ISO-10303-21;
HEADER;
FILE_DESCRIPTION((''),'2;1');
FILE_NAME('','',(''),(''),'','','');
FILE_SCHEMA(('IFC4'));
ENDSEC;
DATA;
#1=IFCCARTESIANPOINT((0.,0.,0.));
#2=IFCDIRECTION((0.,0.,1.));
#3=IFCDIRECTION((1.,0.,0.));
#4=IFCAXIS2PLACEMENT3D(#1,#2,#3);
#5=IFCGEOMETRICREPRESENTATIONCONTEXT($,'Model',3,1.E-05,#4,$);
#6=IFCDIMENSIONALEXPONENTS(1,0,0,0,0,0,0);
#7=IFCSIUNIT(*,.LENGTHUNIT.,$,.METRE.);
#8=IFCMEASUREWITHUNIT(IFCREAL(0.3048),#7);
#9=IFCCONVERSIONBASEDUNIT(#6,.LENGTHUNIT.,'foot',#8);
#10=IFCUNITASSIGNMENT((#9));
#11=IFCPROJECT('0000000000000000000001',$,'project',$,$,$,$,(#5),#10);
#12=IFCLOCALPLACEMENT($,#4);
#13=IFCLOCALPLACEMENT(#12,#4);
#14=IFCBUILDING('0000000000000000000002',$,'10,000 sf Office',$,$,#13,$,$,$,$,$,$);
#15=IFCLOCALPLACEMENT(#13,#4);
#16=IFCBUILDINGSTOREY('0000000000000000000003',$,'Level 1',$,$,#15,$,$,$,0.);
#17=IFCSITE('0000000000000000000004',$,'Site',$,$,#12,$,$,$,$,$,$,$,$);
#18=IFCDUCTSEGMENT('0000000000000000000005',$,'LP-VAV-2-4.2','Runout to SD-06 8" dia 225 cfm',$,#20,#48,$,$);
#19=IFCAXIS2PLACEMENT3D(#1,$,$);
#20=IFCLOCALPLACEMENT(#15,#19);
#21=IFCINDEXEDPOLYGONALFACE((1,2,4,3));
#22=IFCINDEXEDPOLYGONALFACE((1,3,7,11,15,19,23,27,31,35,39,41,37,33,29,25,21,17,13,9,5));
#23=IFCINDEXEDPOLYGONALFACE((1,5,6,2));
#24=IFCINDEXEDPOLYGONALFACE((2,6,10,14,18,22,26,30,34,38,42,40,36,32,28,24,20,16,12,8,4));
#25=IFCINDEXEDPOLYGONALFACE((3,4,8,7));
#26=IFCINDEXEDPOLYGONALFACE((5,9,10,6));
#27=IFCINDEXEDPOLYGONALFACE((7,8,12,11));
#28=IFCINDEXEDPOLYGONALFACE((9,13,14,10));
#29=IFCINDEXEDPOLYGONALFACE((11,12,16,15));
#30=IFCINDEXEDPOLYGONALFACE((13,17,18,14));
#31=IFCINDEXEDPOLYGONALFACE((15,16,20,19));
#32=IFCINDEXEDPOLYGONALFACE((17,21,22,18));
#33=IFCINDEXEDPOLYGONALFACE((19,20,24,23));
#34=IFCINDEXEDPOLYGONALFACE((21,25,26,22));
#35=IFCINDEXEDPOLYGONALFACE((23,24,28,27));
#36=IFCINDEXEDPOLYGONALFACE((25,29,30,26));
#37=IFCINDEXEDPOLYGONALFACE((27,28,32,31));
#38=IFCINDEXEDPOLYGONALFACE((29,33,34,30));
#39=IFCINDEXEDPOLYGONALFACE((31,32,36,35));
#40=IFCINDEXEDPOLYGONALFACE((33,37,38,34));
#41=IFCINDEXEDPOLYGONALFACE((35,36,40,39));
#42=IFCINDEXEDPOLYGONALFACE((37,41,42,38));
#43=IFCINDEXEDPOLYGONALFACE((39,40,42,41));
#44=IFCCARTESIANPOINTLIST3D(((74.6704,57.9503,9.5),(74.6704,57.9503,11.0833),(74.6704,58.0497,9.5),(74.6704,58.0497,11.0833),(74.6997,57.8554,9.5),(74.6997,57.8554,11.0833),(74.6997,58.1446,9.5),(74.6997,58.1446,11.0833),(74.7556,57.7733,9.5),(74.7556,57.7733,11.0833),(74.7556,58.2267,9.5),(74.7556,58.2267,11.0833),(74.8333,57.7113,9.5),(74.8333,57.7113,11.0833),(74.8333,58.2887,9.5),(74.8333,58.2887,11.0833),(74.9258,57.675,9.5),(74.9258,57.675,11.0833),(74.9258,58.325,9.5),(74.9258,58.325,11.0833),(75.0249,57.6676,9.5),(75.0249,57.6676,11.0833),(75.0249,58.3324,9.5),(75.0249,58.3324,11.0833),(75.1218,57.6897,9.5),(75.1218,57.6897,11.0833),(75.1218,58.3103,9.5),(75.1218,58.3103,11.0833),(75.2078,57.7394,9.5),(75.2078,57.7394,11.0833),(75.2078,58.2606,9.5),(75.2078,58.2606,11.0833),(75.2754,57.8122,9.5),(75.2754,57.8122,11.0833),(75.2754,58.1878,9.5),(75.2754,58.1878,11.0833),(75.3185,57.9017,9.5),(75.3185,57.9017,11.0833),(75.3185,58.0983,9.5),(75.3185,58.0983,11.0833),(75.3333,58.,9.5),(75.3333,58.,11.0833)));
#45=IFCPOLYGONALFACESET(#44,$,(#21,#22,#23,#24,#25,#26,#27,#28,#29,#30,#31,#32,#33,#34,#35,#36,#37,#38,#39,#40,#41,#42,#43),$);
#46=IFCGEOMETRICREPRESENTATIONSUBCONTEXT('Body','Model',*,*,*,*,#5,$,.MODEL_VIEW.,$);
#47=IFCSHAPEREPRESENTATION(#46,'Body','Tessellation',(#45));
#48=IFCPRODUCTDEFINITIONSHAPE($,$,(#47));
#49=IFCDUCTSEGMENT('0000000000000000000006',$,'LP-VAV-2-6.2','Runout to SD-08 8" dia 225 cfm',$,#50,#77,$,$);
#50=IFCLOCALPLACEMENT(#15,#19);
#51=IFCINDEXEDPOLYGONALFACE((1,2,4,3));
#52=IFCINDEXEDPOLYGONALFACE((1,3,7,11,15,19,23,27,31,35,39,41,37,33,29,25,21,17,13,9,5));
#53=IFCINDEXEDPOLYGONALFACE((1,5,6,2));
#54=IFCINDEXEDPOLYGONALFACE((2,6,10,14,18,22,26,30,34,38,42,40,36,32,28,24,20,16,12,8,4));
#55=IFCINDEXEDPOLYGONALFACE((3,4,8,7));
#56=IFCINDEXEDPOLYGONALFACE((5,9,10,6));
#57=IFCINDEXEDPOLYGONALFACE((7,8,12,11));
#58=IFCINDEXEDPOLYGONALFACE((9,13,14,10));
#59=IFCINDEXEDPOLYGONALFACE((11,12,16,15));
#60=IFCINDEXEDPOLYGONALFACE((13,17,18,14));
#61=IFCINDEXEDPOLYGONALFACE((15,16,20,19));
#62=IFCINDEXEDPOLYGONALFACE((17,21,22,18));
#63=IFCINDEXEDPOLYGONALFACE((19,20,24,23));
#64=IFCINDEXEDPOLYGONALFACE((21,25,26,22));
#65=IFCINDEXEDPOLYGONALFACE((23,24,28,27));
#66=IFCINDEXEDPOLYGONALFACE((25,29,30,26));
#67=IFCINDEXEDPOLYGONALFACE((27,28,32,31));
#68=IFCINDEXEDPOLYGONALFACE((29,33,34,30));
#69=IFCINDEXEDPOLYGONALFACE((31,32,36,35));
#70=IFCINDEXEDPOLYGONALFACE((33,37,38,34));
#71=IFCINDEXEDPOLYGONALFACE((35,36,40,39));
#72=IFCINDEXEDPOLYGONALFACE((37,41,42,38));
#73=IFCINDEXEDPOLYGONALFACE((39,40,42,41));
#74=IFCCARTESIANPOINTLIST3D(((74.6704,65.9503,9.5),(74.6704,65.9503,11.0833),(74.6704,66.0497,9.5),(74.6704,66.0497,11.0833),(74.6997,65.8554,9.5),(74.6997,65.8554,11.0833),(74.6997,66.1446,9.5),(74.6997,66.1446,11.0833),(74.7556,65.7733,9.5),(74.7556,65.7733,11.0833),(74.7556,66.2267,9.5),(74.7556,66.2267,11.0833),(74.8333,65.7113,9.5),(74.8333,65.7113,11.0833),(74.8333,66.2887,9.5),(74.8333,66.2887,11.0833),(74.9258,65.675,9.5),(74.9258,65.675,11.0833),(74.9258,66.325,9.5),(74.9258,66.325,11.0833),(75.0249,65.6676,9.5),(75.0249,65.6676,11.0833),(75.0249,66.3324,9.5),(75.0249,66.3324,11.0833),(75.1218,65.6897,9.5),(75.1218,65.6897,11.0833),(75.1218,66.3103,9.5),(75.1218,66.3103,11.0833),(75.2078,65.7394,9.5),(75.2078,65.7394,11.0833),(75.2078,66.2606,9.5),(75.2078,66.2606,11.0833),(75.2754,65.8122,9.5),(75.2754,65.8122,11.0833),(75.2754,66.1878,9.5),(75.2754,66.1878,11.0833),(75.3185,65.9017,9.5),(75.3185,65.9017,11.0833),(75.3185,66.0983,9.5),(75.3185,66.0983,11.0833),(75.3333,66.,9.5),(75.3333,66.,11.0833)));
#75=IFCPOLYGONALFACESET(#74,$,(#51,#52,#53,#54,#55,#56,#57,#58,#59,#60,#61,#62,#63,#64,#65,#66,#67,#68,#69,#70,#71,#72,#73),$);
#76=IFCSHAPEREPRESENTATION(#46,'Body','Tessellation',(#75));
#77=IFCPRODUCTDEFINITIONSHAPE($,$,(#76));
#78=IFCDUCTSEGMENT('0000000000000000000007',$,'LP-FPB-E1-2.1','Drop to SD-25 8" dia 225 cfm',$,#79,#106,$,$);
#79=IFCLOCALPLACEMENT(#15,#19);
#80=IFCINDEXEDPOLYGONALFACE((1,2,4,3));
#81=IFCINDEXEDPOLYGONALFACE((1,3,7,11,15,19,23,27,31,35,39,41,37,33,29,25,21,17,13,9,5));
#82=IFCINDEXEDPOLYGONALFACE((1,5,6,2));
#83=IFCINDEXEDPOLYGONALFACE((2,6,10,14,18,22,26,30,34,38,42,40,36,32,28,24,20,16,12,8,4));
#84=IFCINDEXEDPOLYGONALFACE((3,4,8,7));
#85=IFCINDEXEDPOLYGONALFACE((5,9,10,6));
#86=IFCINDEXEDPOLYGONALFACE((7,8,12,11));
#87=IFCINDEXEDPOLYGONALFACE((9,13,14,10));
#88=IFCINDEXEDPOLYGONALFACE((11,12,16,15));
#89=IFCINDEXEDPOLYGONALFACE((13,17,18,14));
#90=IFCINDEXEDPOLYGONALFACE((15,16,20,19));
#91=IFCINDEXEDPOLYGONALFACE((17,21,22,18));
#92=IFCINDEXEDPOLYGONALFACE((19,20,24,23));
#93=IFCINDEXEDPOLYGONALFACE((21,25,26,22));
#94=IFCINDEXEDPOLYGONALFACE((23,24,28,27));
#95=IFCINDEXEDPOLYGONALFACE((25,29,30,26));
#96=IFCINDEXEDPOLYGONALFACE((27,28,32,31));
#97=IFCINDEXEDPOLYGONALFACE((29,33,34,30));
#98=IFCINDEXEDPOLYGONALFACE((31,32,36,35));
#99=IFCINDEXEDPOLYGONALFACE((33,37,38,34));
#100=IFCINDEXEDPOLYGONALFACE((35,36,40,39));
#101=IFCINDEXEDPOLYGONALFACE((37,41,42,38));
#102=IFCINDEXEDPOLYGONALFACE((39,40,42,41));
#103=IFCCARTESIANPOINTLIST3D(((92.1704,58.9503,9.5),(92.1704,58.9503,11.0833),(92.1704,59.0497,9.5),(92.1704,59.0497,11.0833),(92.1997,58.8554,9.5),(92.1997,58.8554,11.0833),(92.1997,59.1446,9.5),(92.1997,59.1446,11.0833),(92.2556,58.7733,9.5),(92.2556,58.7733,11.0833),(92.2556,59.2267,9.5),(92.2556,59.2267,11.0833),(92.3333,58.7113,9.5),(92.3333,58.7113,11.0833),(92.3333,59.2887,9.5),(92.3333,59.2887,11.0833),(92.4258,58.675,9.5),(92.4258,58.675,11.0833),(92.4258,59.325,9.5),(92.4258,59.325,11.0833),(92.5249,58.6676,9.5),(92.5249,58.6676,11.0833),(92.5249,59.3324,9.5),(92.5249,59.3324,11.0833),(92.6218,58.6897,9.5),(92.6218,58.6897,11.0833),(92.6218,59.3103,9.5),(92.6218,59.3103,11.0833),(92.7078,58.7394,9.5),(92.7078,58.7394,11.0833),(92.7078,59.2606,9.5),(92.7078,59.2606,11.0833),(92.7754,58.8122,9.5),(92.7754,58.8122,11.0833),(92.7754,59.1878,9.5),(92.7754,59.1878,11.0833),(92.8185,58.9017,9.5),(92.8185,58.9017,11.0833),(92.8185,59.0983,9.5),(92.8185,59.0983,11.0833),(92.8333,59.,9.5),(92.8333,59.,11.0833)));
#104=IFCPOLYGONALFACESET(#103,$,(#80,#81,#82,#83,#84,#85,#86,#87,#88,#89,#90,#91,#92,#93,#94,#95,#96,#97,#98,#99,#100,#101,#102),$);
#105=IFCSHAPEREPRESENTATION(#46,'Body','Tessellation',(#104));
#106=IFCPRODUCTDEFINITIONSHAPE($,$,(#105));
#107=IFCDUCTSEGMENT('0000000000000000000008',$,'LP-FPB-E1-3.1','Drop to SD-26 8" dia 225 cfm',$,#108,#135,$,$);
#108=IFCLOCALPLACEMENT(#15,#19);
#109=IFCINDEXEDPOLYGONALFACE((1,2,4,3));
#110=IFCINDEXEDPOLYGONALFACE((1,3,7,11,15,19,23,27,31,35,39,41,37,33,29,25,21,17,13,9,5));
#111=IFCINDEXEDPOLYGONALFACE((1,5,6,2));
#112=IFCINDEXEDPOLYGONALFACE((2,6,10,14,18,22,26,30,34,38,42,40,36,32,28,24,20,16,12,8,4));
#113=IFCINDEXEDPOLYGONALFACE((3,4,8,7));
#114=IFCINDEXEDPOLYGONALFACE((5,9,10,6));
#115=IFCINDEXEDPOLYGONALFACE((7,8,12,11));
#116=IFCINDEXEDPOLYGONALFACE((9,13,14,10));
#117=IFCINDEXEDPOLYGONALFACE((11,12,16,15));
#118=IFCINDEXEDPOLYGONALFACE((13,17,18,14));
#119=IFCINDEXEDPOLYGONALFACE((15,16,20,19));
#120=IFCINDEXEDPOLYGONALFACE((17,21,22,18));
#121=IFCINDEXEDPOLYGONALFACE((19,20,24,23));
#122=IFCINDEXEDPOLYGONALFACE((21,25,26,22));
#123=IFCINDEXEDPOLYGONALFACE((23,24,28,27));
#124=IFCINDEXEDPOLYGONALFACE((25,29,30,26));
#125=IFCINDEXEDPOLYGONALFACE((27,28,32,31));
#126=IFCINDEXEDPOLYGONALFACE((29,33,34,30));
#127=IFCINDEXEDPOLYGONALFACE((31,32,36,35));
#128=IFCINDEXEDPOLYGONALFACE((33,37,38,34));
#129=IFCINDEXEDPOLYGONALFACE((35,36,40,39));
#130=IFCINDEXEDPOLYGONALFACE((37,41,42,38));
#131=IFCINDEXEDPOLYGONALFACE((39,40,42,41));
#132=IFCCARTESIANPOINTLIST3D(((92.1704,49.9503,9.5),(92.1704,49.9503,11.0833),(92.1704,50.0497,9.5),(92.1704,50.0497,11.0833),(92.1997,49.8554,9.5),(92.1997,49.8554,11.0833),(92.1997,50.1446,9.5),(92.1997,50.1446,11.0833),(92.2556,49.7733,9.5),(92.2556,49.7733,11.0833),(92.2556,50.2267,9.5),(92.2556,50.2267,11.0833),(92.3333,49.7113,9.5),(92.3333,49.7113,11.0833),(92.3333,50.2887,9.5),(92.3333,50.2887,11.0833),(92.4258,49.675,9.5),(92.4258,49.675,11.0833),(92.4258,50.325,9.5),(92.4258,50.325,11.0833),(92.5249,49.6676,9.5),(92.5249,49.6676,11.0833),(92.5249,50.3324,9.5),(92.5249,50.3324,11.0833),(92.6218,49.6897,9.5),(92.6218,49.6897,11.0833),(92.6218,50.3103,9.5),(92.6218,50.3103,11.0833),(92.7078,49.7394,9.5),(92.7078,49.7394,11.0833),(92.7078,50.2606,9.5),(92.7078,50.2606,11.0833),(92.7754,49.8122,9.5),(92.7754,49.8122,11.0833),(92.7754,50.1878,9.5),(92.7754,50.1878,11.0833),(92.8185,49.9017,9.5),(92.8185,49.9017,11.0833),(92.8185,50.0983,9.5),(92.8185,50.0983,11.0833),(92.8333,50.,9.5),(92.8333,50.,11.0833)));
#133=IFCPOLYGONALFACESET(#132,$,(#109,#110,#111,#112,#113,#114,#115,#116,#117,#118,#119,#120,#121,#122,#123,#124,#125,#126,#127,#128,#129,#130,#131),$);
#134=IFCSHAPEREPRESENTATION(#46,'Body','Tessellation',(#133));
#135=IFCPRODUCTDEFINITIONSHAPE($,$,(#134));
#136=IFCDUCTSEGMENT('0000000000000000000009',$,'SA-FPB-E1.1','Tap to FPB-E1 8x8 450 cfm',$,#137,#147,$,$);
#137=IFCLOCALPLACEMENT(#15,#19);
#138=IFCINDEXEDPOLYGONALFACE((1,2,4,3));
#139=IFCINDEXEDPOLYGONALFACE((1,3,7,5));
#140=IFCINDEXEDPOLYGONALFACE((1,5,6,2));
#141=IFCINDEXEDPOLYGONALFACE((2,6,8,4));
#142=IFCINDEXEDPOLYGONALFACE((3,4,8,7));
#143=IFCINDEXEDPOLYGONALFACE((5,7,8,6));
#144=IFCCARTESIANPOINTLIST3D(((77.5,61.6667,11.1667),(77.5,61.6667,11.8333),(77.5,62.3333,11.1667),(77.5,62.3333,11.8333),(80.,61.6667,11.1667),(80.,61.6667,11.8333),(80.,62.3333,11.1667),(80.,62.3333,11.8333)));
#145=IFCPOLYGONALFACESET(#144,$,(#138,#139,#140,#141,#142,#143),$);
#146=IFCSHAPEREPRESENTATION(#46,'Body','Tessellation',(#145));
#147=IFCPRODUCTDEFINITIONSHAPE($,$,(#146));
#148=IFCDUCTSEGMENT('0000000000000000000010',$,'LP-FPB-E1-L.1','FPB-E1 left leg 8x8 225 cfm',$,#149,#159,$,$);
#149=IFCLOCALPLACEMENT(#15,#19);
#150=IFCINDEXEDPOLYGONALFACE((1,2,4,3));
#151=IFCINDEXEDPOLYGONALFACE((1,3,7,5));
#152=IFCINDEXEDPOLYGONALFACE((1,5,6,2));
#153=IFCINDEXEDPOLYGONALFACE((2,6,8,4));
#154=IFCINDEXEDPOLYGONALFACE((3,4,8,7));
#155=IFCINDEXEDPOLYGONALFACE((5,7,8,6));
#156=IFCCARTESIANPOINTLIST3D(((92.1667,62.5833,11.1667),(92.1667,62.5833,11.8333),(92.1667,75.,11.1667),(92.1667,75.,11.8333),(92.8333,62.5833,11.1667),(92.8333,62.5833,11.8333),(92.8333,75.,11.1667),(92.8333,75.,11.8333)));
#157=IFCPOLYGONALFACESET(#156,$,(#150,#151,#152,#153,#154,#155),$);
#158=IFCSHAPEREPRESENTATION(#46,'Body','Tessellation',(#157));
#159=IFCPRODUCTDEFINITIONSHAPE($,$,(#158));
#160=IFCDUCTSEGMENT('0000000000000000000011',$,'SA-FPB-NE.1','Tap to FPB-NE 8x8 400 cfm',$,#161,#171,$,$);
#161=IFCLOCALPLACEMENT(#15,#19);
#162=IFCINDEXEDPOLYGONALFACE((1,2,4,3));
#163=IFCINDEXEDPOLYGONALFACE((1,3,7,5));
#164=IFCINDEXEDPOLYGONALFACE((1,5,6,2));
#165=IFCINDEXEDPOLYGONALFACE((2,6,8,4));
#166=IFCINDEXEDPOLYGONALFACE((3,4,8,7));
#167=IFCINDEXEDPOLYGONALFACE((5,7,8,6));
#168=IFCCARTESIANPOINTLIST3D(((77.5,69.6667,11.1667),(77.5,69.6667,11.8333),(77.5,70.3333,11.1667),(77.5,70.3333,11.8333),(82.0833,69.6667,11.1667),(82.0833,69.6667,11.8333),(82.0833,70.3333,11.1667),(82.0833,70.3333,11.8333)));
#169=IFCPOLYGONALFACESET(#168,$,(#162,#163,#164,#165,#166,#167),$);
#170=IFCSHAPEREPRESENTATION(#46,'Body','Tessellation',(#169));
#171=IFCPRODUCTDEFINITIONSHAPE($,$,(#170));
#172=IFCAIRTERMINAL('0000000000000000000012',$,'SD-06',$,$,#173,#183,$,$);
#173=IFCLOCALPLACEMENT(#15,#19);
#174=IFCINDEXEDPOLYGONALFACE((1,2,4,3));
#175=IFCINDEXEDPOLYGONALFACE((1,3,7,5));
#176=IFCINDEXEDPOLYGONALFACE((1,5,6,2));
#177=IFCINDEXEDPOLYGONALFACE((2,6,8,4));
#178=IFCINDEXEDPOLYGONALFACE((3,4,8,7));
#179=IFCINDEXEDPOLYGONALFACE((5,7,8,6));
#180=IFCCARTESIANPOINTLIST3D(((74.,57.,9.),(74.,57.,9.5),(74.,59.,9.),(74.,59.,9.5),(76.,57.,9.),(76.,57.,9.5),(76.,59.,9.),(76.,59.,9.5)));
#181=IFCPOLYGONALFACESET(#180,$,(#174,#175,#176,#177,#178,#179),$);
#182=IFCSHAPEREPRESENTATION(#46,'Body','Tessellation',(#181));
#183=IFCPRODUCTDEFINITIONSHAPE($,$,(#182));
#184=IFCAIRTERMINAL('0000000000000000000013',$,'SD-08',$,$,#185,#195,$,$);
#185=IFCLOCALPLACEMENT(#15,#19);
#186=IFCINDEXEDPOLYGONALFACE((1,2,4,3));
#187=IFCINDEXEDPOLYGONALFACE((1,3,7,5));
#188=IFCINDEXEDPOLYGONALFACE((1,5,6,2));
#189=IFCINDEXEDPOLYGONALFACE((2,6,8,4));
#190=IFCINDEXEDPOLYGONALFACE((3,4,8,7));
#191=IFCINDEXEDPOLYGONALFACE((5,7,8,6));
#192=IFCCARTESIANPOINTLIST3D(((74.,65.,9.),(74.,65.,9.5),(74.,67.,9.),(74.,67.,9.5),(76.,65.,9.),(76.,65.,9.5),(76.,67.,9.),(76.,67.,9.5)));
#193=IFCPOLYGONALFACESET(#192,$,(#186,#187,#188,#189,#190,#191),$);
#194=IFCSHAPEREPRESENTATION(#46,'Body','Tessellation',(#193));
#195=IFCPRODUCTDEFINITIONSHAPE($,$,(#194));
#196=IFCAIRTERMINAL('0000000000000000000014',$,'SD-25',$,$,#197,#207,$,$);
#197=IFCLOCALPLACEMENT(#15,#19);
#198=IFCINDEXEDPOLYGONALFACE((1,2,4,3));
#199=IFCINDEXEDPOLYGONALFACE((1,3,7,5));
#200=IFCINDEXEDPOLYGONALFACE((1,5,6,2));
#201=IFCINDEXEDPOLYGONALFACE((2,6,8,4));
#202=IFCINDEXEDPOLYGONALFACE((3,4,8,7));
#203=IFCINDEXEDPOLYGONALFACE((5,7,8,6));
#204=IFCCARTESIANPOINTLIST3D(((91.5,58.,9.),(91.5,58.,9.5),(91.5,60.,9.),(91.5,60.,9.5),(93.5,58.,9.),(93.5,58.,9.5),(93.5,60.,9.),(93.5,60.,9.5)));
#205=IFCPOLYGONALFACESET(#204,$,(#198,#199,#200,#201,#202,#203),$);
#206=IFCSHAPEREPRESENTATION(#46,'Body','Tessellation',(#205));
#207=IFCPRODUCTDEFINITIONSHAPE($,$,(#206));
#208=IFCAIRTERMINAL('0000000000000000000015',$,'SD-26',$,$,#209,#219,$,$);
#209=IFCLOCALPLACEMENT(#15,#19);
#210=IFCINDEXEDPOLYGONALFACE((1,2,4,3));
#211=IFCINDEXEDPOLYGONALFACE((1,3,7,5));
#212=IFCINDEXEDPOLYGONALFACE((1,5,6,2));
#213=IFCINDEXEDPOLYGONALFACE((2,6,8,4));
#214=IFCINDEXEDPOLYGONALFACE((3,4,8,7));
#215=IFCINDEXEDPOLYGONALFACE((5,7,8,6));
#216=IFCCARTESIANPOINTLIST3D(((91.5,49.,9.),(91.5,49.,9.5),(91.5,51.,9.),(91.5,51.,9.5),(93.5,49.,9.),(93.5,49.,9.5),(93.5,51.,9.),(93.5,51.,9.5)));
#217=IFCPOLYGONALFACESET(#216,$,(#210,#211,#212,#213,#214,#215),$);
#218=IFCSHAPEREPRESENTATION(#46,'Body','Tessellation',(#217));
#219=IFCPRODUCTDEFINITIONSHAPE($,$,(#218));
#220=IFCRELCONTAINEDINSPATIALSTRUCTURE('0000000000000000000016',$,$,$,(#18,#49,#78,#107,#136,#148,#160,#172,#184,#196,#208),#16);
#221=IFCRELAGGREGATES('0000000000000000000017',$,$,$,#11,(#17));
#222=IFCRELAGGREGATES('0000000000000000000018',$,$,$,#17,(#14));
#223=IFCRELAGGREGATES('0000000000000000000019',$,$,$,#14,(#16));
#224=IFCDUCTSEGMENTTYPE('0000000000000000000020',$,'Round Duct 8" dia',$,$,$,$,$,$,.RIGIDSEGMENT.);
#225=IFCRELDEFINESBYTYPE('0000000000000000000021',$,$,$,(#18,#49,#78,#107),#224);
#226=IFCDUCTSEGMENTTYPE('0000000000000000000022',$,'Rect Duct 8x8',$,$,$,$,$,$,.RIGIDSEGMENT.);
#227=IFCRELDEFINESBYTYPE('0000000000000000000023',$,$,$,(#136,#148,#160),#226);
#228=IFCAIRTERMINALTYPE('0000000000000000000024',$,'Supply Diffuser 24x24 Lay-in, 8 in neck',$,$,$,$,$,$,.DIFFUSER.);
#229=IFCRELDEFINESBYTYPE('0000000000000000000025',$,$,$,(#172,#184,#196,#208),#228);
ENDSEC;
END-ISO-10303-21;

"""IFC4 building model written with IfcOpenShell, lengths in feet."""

from ifc_helpers import new_model, entity, si_unit, converted_unit, frame, origin_with_axes, place, context, subcontext, project, spatial, rectangle, circle, extrude, type_object, element, save


model = new_model("IFC4")

# Units and contexts
model_context = context("Model", 3, precision=1e-05, world=origin_with_axes())
body_context = subcontext(model_context, "Body", "Model", "MODEL_VIEW")
ifc_project = project(units=[converted_unit("LENGTHUNIT", "foot", entity("IfcReal", 0.3048), si_unit("LENGTHUNIT", "METRE"), dimensions=[1, 0, 0, 0, 0, 0, 0])], contexts=[model_context])

# Site, building, storey
site_placement = place(None, origin_with_axes())
site = spatial("IfcSite", under=ifc_project, at=site_placement, Name="Site")
building_placement = place(site_placement, origin_with_axes())
building = spatial("IfcBuilding", under=site, at=building_placement, Name="10,000 sf Office")
storey_placement = place(building_placement, origin_with_axes())
storey = spatial("IfcBuildingStorey", under=building, at=storey_placement, Name="Level 1", Elevation=0.0)

# Duct segments
duct_segment_type_1 = type_object("IfcDuctSegmentType", Name="Round Duct 8\" dia", PredefinedType="RIGIDSEGMENT")
for number, where, z_axis, x_axis, name, description in (
    (1, (75.0, 58.0, 11.0833), (0.0, 0.0, -1.0), (1.0, 0.0, 0.0), "LP-VAV-2-4.2", "Runout to SD-06 8\" dia 225 cfm"),
    (2, (75.0, 66.0, 11.0833), (0.0, 0.0, -1.0), (1.0, 0.0, 0.0), "LP-VAV-2-6.2", "Runout to SD-08 8\" dia 225 cfm"),
    (3, (92.5, 59.0, 11.0833), (0.0, 0.0, -1.0), (1.0, 0.0, 0.0), "LP-FPB-E1-2.1", "Drop to SD-25 8\" dia 225 cfm"),
    (4, (92.5, 50.0, 11.0833), (0.0, 0.0, -1.0), (1.0, 0.0, 0.0), "LP-FPB-E1-3.1", "Drop to SD-26 8\" dia 225 cfm"),
):
    element("IfcDuctSegment", number, at=place(storey_placement, frame(where, z_axis=z_axis, x_axis=x_axis)), inside=storey, type_object=duct_segment_type_1, Name=name, Description=description, context=body_context, shape_type="SweptSolid", body=[
        extrude(circle(Radius=0.3333), None, (0.0, 0.0, 1.0), 1.5833),
    ])
duct_segment_type_2 = type_object("IfcDuctSegmentType", Name="Rect Duct 8x8", PredefinedType="RIGIDSEGMENT")
duct_segment_1_placement = place(storey_placement, frame((77.5, 62.0, 11.5), z_axis=(1.0, 0.0, 0.0), x_axis=(0.0, 1.0, 0.0)))
element("IfcDuctSegment", 5, at=duct_segment_1_placement, inside=storey, type_object=duct_segment_type_2, Name="SA-FPB-E1.1", Description="Tap to FPB-E1 8x8 450 cfm", context=body_context, shape_type="SweptSolid", body=[
    extrude(rectangle(XDim=0.6667, YDim=0.6667), None, (0.0, 0.0, 1.0), 2.5),
])
duct_segment_2_placement = place(storey_placement, frame((92.5, 62.5833, 11.5), z_axis=(0.0, 1.0, 0.0), x_axis=(-1.0, 0.0, 0.0)))
element("IfcDuctSegment", 6, at=duct_segment_2_placement, inside=storey, type_object=duct_segment_type_2, Name="LP-FPB-E1-L.1", Description="FPB-E1 left leg 8x8 225 cfm", context=body_context, shape_type="SweptSolid", body=[
    extrude(rectangle(XDim=0.6667, YDim=0.6667), None, (0.0, 0.0, 1.0), 12.4167),
])
duct_segment_3_placement = place(storey_placement, frame((77.5, 70.0, 11.5), z_axis=(1.0, 0.0, 0.0), x_axis=(0.0, 1.0, 0.0)))
element("IfcDuctSegment", 7, at=duct_segment_3_placement, inside=storey, type_object=duct_segment_type_2, Name="SA-FPB-NE.1", Description="Tap to FPB-NE 8x8 400 cfm", context=body_context, shape_type="SweptSolid", body=[
    extrude(rectangle(XDim=0.6667, YDim=0.6667), None, (0.0, 0.0, 1.0), 4.5833),
])

# Air terminals
air_terminal_type_1 = type_object("IfcAirTerminalType", Name="Supply Diffuser 24x24 Lay-in, 8 in neck", PredefinedType="DIFFUSER")
for number, where, z_axis, x_axis, name in (
    (8, (75.0, 58.0, 9.0), (0.0, 0.0, 1.0), (1.0, 0.0, 0.0), "SD-06"),
    (9, (75.0, 66.0, 9.0), (0.0, 0.0, 1.0), (1.0, 0.0, 0.0), "SD-08"),
    (10, (92.5, 59.0, 9.0), (0.0, 0.0, 1.0), (1.0, 0.0, 0.0), "SD-25"),
    (11, (92.5, 50.0, 9.0), (0.0, 0.0, 1.0), (1.0, 0.0, 0.0), "SD-26"),
):
    element("IfcAirTerminal", number, at=place(storey_placement, frame(where, z_axis=z_axis, x_axis=x_axis)), inside=storey, type_object=air_terminal_type_1, Name=name, context=body_context, shape_type="SweptSolid", body=[
        extrude(rectangle(XDim=2.0, YDim=2.0), None, (0.0, 0.0, 1.0), 0.5),
    ])

save(model, "model.ifc")
